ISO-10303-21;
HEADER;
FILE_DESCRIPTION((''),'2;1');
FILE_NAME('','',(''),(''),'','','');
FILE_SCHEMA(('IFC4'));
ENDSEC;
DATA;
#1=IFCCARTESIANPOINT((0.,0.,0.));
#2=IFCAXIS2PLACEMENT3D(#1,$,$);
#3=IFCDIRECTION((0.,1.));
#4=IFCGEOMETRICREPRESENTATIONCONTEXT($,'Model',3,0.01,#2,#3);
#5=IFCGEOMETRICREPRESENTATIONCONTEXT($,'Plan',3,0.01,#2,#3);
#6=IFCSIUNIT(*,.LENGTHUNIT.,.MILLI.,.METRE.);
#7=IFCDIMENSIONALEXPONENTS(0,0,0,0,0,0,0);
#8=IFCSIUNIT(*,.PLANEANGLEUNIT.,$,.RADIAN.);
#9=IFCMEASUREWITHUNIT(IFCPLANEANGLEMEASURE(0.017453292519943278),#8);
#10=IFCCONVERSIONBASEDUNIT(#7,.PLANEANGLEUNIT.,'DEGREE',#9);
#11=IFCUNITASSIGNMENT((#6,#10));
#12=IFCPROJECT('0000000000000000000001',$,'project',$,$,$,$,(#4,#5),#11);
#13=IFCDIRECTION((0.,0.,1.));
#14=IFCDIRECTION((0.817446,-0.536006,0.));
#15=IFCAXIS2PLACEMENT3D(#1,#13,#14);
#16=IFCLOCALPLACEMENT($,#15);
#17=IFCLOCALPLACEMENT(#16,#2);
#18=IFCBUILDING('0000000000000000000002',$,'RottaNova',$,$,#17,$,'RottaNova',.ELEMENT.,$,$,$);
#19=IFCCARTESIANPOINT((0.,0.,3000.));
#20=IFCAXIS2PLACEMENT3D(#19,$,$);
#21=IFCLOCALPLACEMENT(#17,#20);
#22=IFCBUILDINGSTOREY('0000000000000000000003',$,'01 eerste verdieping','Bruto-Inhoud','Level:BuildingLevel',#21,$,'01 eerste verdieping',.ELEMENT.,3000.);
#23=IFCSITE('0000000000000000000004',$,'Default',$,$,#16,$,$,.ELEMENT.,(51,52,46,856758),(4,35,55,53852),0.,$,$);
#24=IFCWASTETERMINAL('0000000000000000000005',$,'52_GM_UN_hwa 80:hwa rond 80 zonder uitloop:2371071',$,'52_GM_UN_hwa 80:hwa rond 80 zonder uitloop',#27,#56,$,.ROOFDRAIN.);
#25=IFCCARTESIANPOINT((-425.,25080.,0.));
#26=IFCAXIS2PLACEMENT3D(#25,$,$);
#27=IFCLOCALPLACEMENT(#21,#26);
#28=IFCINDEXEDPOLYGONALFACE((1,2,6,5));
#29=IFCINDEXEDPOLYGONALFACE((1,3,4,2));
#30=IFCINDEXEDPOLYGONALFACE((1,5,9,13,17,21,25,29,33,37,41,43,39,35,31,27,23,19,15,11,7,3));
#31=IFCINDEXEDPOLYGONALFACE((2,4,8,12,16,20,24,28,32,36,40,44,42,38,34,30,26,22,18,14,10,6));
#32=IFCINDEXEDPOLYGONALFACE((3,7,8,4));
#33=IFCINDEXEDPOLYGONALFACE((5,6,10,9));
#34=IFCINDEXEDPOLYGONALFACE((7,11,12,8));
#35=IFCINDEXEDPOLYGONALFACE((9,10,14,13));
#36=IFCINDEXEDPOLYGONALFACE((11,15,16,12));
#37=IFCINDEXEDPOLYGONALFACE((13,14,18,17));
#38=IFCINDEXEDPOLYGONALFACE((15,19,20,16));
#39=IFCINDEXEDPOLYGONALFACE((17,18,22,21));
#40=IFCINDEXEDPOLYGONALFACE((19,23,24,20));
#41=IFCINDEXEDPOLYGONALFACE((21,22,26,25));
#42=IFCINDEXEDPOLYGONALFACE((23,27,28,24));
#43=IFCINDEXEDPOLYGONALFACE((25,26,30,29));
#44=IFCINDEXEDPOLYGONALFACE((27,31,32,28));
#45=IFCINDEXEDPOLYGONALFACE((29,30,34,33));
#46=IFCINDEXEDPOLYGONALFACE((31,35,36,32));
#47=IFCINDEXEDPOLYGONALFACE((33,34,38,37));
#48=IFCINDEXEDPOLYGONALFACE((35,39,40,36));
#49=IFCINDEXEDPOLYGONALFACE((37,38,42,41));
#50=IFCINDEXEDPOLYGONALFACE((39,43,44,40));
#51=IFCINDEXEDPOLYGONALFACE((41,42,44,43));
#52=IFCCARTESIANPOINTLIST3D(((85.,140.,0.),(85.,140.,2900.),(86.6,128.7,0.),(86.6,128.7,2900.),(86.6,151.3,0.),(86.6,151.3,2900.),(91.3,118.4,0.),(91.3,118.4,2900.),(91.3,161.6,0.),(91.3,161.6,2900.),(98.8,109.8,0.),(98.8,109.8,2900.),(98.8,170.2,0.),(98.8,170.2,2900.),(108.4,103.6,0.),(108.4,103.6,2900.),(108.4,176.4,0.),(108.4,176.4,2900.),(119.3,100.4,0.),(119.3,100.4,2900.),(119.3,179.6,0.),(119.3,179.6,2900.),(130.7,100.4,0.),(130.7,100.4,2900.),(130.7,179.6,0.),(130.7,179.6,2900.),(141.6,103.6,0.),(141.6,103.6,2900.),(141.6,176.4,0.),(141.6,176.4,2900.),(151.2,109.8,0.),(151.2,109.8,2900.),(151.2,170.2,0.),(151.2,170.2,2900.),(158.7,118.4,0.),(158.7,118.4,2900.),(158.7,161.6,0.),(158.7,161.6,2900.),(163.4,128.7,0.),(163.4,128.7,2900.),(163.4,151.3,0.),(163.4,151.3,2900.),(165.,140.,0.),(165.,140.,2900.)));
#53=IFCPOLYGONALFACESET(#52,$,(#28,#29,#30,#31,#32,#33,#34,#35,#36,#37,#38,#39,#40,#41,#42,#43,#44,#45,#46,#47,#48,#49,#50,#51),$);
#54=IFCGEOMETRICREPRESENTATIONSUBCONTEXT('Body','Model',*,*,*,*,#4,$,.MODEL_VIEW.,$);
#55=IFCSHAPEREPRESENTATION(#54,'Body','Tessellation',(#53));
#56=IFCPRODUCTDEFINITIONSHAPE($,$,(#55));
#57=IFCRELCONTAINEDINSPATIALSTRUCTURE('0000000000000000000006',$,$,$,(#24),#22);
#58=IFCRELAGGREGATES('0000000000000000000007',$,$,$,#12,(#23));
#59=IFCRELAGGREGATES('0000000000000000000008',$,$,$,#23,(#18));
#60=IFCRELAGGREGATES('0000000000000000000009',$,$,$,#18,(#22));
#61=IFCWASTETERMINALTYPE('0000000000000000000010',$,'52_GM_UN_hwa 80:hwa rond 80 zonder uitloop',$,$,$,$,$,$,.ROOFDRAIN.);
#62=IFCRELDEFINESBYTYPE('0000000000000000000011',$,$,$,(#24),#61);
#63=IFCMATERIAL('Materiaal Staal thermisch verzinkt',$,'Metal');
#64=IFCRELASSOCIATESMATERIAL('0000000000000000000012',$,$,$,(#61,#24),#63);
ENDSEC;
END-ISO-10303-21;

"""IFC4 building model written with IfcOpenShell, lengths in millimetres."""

from ifc_helpers import new_model, entity, si_unit, converted_unit, direction, frame, origin, place, context, subcontext, project, spatial, arc, indexed_curve, outline, extrude, source, transform, mapped, material, type_object, type_shapes, element, save


model = new_model("IFC4")

# Units and contexts
model_context = context("Model", 3, precision=0.01, world=origin(), true_north=direction((0.0, 1.0)))
plan_context = context("Plan", 3, precision=0.01, world=origin(), true_north=direction((0.0, 1.0)))
body_context = subcontext(model_context, "Body", "Model", "MODEL_VIEW")
ifc_project = project(units=[si_unit("LENGTHUNIT", "METRE", prefix="MILLI"), converted_unit("PLANEANGLEUNIT", "DEGREE", entity("IfcPlaneAngleMeasure", 0.017453292519943278), si_unit("PLANEANGLEUNIT", "RADIAN"), dimensions=[0, 0, 0, 0, 0, 0, 0])], contexts=[model_context, plan_context])

# Site, building, storey
site_placement = place(None, frame((0.0, 0.0, 0.0), z_axis=(0.0, 0.0, 1.0), x_axis=(0.817446, -0.536006, 0.0)))
site = spatial("IfcSite", under=ifc_project, at=site_placement, Name="Default", CompositionType="ELEMENT", RefLatitude=(51, 52, 46, 856758), RefLongitude=(4, 35, 55, 53852), RefElevation=0.0)
building_placement = place(site_placement, origin())
building = spatial("IfcBuilding", under=site, at=building_placement, Name="RottaNova", LongName="RottaNova", CompositionType="ELEMENT")
storey_placement = place(building_placement, frame((0.0, 0.0, 3000.0)))
storey = spatial("IfcBuildingStorey", under=building, at=storey_placement, Name="01 eerste verdieping", Description="Bruto-Inhoud", ObjectType="Level:BuildingLevel", LongName="01 eerste verdieping", CompositionType="ELEMENT", Elevation=3000.0)

# Waste terminal
ifc_material_1 = material(Name="Materiaal Staal thermisch verzinkt", Category="Metal")
waste_terminal_type = type_object("IfcWasteTerminalType", Name="52_GM_UN_hwa 80:hwa rond 80 zonder uitloop", PredefinedType="ROOFDRAIN", material=ifc_material_1)
shared_shape_1 = source(origin(), body_context, "Body", "SweptSolid", [
    extrude(outline(indexed_curve([(-40.0, 0.0), (0.0, -40.0), (40.0, 0.0), (0.0, 40.0)], segments=[arc(1, 2, 3), arc(3, 4, 1)], self_intersect=False)), frame((125.0, 140.0, 0.0)), (0.0, 0.0, 1.0), 2900.0),
])
type_shapes(waste_terminal_type, [shared_shape_1])
waste_terminal_placement = place(storey_placement, frame((-425.0, 25080.0, 0.0)))
element("IfcWasteTerminal", 1, at=waste_terminal_placement, inside=storey, type_object=waste_terminal_type, material=ifc_material_1, Name="52_GM_UN_hwa 80:hwa rond 80 zonder uitloop:2371071", ObjectType="52_GM_UN_hwa 80:hwa rond 80 zonder uitloop", PredefinedType="ROOFDRAIN", context=body_context, shape_type="MappedRepresentation", body=[
    mapped(shared_shape_1, transform((0.0, 0.0, 0.0), scale=1.0)),
])

save(model, "model.ifc")
